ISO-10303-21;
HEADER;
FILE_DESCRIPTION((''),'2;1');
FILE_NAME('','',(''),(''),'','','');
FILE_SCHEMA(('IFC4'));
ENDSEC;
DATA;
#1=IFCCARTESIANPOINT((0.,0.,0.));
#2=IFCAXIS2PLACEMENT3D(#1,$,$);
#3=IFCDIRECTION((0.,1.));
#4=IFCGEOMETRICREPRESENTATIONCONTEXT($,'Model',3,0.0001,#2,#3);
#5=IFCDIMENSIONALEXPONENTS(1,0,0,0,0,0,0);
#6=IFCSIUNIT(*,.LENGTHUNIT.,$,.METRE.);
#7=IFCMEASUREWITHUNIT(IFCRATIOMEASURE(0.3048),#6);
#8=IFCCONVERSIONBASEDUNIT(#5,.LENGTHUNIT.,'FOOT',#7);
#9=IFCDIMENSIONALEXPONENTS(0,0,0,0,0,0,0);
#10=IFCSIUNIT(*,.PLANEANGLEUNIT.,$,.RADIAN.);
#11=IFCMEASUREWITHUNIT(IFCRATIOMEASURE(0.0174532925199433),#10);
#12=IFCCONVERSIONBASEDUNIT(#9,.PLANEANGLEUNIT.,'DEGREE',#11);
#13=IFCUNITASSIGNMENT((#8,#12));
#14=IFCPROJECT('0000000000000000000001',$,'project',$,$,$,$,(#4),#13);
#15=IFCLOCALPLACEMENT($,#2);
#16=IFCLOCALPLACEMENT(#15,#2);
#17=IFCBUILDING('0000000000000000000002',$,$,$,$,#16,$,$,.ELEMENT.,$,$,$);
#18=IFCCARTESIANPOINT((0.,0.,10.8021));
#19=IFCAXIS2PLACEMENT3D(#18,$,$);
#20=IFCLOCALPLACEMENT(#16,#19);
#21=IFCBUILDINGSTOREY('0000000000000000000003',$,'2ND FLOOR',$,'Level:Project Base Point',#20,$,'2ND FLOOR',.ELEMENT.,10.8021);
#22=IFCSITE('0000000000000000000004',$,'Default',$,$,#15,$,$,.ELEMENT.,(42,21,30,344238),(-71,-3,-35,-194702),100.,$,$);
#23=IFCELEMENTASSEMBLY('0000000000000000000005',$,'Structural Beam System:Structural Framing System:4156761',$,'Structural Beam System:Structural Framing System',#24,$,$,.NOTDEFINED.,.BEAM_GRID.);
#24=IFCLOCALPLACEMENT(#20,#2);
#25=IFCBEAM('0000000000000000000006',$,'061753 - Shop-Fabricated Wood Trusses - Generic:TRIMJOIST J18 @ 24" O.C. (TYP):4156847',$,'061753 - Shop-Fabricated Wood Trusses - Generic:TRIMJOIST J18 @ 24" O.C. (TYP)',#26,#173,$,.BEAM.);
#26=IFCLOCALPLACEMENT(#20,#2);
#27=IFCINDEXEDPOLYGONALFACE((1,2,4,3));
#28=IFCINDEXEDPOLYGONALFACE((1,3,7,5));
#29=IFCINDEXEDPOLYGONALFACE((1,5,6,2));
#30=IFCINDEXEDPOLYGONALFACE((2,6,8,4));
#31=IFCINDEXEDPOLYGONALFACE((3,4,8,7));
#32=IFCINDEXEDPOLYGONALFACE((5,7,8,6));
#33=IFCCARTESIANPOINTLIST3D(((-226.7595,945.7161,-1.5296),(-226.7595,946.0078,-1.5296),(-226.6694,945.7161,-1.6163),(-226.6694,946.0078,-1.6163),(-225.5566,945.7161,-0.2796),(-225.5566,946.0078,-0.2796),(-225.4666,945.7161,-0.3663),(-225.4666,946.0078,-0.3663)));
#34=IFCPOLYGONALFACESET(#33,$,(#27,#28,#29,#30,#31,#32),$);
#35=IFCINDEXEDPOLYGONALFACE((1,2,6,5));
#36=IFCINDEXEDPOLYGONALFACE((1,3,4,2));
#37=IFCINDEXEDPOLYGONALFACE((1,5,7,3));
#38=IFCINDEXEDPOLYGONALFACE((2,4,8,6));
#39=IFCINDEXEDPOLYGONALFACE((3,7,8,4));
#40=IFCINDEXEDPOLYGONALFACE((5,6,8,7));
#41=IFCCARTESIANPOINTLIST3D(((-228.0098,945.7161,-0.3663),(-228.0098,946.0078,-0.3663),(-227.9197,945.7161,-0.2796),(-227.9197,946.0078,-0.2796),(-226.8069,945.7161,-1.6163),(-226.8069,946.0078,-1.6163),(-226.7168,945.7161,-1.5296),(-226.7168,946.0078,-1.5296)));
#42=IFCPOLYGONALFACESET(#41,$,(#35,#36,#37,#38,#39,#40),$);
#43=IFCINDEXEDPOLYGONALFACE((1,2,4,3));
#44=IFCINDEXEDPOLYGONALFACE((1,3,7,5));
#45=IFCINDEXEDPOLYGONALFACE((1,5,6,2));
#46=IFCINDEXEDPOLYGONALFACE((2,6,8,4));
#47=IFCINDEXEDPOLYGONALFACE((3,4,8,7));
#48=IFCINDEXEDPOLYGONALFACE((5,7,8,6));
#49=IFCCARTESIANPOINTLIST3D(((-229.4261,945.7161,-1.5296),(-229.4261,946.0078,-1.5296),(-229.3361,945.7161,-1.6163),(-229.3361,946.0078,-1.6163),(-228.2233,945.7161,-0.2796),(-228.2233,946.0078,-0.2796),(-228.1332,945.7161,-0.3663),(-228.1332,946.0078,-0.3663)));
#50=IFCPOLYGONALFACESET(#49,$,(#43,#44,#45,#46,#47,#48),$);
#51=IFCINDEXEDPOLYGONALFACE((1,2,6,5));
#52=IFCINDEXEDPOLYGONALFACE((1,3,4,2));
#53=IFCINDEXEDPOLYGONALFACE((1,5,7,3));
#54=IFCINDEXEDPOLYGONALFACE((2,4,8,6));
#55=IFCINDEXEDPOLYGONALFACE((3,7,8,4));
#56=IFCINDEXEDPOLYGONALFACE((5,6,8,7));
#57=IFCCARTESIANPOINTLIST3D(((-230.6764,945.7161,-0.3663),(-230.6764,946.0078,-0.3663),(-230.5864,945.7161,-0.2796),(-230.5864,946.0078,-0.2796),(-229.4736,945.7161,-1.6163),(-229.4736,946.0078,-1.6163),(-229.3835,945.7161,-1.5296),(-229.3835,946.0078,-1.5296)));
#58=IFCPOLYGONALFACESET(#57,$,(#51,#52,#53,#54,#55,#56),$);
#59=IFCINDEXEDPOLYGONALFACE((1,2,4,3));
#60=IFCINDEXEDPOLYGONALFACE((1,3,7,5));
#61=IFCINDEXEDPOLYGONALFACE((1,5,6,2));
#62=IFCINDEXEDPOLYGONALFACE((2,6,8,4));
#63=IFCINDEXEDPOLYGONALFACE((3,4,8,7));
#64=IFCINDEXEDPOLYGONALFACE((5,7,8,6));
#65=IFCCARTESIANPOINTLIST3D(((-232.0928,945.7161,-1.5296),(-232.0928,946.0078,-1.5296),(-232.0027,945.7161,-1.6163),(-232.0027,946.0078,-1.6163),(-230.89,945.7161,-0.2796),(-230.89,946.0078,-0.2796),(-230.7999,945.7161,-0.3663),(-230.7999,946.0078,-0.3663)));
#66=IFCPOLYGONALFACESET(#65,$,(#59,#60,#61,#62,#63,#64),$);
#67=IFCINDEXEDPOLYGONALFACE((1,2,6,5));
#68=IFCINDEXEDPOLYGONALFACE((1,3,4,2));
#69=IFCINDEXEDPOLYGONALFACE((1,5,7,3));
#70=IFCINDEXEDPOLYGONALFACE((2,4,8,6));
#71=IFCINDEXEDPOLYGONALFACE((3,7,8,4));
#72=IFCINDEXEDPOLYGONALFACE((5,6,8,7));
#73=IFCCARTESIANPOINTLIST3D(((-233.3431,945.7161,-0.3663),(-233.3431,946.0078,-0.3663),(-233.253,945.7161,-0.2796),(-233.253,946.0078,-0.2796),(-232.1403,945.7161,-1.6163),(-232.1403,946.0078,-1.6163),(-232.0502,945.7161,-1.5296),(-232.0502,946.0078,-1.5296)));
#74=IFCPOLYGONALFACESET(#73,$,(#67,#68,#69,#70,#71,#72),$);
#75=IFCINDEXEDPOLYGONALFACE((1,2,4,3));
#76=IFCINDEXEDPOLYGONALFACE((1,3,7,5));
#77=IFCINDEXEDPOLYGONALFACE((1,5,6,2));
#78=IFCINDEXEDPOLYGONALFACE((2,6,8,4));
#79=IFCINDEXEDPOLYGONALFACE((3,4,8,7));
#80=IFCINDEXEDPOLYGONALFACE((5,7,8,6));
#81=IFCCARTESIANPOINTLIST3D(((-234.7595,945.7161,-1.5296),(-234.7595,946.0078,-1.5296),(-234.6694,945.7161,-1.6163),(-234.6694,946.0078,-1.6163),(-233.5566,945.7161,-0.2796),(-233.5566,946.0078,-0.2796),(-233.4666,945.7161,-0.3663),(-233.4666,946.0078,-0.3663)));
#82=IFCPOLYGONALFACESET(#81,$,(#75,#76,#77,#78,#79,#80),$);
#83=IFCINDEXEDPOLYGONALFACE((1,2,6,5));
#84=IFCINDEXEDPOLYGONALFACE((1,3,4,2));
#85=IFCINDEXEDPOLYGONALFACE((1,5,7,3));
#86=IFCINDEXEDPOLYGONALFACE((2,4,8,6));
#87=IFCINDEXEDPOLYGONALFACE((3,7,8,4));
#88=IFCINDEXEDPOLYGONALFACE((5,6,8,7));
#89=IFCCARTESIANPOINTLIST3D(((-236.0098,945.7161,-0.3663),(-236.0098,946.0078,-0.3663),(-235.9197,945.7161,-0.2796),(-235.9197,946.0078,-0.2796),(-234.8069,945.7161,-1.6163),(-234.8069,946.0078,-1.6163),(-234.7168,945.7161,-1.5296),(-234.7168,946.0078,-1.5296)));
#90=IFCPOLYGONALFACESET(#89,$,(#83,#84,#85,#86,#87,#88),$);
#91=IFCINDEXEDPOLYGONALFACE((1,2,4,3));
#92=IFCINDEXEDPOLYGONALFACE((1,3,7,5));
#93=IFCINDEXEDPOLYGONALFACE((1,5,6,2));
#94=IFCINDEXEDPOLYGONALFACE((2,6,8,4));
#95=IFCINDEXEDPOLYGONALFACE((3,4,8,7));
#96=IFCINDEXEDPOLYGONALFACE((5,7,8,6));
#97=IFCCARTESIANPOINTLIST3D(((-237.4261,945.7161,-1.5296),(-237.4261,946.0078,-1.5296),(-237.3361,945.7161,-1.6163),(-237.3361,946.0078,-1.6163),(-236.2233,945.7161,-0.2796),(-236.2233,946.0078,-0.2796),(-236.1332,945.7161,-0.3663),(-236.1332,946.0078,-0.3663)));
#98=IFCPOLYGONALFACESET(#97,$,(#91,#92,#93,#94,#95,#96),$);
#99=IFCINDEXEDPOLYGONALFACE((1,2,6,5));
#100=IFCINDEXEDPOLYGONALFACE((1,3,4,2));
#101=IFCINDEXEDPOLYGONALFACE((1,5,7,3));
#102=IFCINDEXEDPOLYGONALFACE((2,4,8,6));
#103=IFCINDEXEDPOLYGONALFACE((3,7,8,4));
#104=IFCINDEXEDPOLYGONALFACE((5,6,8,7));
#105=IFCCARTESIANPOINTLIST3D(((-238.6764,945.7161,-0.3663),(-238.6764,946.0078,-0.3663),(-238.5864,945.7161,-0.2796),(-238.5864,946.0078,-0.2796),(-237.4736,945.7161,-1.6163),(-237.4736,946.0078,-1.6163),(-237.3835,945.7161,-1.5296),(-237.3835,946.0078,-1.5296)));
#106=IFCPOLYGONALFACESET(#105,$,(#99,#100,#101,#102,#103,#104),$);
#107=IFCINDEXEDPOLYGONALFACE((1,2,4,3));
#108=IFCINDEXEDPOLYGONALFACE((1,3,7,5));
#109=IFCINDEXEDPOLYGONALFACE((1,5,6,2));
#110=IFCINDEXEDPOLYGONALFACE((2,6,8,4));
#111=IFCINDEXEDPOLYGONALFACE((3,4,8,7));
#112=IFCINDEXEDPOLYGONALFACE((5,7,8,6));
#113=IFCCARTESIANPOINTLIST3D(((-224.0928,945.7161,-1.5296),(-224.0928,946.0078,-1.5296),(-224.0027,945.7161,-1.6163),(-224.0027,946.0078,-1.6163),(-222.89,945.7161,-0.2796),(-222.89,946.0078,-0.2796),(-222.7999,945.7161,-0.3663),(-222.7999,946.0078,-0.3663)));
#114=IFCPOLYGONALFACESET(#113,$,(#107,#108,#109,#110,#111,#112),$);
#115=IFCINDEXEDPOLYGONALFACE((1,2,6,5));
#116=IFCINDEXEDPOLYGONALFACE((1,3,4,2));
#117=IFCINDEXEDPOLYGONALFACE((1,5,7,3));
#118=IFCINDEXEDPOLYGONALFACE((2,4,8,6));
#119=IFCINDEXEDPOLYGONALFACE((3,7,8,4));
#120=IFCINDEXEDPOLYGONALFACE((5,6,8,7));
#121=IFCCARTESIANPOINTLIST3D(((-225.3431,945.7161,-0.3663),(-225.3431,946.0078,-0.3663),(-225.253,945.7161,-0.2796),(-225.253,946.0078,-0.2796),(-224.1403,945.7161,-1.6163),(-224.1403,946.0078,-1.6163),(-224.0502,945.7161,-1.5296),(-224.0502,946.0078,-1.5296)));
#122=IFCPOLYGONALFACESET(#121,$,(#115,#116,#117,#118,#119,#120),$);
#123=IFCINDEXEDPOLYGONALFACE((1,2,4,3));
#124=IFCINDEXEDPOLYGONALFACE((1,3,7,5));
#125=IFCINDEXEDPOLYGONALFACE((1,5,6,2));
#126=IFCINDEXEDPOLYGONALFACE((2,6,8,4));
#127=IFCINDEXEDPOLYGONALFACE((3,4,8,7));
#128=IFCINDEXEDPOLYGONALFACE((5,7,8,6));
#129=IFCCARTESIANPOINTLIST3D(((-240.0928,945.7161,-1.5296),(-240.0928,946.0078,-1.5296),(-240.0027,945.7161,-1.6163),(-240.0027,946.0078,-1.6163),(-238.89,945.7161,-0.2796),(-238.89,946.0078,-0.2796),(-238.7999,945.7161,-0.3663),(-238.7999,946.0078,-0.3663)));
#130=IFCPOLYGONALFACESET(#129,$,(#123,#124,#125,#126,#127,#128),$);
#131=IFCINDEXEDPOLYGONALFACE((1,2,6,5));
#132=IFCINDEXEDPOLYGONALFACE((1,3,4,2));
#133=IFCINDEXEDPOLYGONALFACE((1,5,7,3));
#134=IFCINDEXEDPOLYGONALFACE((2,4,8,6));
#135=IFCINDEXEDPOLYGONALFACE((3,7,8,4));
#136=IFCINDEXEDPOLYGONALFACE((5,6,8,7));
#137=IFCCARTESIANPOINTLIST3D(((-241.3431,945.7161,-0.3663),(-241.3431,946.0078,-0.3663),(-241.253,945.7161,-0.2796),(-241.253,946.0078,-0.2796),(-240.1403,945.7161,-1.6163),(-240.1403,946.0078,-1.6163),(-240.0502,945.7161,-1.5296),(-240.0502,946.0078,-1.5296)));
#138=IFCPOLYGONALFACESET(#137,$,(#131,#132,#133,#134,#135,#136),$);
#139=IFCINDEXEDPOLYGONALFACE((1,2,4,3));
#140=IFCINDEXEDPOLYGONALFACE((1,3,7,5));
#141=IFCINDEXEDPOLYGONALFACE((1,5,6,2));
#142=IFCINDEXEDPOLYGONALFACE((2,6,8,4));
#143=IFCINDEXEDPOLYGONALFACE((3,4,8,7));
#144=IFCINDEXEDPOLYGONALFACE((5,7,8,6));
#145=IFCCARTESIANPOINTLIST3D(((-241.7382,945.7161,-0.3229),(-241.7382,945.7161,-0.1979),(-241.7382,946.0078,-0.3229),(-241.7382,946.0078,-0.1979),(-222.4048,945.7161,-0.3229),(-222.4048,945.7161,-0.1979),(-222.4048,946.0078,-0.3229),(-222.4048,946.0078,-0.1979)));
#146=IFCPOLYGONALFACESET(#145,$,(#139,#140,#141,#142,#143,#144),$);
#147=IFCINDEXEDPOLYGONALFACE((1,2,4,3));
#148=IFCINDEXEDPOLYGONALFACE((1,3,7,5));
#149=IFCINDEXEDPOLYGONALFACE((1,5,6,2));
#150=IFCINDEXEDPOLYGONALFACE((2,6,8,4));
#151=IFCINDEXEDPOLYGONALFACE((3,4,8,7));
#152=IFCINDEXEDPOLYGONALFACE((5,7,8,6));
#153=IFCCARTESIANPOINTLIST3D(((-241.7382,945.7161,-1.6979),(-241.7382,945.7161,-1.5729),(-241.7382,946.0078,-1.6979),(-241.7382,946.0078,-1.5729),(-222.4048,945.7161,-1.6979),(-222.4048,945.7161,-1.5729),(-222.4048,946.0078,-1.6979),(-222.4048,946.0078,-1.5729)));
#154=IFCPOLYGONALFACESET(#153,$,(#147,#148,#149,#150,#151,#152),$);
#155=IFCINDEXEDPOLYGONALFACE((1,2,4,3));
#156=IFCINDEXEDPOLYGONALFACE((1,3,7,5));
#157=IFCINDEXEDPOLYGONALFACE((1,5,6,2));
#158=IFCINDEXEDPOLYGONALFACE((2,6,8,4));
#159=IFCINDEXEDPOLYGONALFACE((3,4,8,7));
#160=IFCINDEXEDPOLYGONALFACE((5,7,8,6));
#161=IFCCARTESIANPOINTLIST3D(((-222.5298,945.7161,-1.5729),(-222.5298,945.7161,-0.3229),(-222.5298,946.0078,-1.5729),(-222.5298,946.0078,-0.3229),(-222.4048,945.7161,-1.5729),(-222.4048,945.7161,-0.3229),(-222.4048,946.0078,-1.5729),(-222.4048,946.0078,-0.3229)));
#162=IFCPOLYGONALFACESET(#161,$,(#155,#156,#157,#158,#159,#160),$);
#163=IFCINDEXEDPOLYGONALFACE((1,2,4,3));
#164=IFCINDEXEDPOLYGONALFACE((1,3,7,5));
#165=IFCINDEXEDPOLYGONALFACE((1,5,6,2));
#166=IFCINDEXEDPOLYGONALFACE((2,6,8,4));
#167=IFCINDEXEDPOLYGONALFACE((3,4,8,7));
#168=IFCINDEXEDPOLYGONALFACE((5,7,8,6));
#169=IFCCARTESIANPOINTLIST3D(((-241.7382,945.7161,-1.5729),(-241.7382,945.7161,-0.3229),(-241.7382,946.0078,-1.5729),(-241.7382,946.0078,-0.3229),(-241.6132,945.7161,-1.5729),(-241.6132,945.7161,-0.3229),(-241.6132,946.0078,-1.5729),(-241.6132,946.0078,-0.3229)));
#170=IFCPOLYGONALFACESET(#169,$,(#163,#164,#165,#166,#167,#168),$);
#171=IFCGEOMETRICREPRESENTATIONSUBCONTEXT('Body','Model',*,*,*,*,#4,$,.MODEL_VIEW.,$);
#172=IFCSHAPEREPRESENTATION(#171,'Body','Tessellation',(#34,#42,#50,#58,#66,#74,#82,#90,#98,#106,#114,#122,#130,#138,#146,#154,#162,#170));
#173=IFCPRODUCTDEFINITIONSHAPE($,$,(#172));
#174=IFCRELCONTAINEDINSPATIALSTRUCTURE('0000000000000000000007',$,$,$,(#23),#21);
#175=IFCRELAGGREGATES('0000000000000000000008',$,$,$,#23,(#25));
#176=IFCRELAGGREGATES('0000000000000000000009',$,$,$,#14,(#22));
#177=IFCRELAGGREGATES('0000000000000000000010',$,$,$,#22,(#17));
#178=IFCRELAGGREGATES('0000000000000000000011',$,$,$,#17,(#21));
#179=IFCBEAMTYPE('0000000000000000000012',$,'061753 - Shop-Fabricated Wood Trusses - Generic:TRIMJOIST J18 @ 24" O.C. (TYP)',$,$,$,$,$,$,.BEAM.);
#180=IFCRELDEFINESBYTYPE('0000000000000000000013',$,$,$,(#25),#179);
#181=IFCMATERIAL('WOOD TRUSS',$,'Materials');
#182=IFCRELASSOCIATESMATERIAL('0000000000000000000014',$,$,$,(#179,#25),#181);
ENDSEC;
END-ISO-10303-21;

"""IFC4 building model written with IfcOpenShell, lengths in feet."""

from ifc_helpers import new_model, entity, si_unit, converted_unit, direction, frame, frame_2d, origin, origin_2d_with_axis, place, context, subcontext, project, spatial, rectangle, extrude, source, transform, mapped, material, material_profile, profile_set, profile_usage, type_object, type_shapes, element, aggregate, save


model = new_model("IFC4")

# Units and contexts
model_context = context("Model", 3, precision=0.0001, world=origin(), true_north=direction((0.0, 1.0)))
body_context = subcontext(model_context, "Body", "Model", "MODEL_VIEW")
ifc_project = project(units=[converted_unit("LENGTHUNIT", "FOOT", entity("IfcRatioMeasure", 0.3048), si_unit("LENGTHUNIT", "METRE"), dimensions=[1, 0, 0, 0, 0, 0, 0]), converted_unit("PLANEANGLEUNIT", "DEGREE", entity("IfcRatioMeasure", 0.0174532925199433), si_unit("PLANEANGLEUNIT", "RADIAN"), dimensions=[0, 0, 0, 0, 0, 0, 0])], contexts=[model_context])

# Site, building, storey
site_placement = place(None, origin())
site = spatial("IfcSite", under=ifc_project, at=site_placement, Name="Default", CompositionType="ELEMENT", RefLatitude=(42, 21, 30, 344238), RefLongitude=(-71, -3, -35, -194702), RefElevation=100.0)
building_placement = place(site_placement, origin())
building = spatial("IfcBuilding", under=site, at=building_placement, CompositionType="ELEMENT")
storey_placement = place(building_placement, frame((0.0, 0.0, 10.8021)))
storey = spatial("IfcBuildingStorey", under=building, at=storey_placement, Name="2ND FLOOR", ObjectType="Level:Project Base Point", LongName="2ND FLOOR", CompositionType="ELEMENT", Elevation=10.8021)

# Element assembly, beam
assembly_1_placement = place(storey_placement, origin())
assembly_1 = element("IfcElementAssembly", 1, at=assembly_1_placement, inside=storey, Name="Structural Beam System:Structural Framing System:4156761", ObjectType="Structural Beam System:Structural Framing System", AssemblyPlace="NOTDEFINED", PredefinedType="BEAM_GRID")
ifc_material_1 = material(Name="WOOD TRUSS", Category="Materials")
ifc_material_profile_1 = material_profile(ifc_material_1, rectangle(XDim=1.7347, YDim=0.125, at=frame_2d((0.0, 0.0), x_axis=(1.0, 0.0))), Name="TRIMJOIST J18 @ 24\" O.C. (TYP)")
ifc_material_profile_2 = material_profile(ifc_material_1, rectangle(XDim=1.7347, YDim=0.125, at=frame_2d((0.0, 0.0), x_axis=(1.0, 0.0))), Name="TRIMJOIST J18 @ 24\" O.C. (TYP)")
ifc_material_profile_3 = material_profile(ifc_material_1, rectangle(XDim=1.7347, YDim=0.125, at=frame_2d((0.0, 0.0), x_axis=(1.0, 0.0))), Name="TRIMJOIST J18 @ 24\" O.C. (TYP)")
ifc_material_profile_4 = material_profile(ifc_material_1, rectangle(XDim=1.7347, YDim=0.125, at=frame_2d((0.0, 0.0), x_axis=(1.0, 0.0))), Name="TRIMJOIST J18 @ 24\" O.C. (TYP)")
ifc_material_profile_5 = material_profile(ifc_material_1, rectangle(XDim=1.7347, YDim=0.125, at=frame_2d((0.0, 0.0), x_axis=(1.0, 0.0))), Name="TRIMJOIST J18 @ 24\" O.C. (TYP)")
ifc_material_profile_6 = material_profile(ifc_material_1, rectangle(XDim=1.7347, YDim=0.125, at=frame_2d((0.0, 0.0), x_axis=(1.0, 0.0))), Name="TRIMJOIST J18 @ 24\" O.C. (TYP)")
ifc_material_profile_7 = material_profile(ifc_material_1, rectangle(XDim=1.7347, YDim=0.125, at=frame_2d((0.0, 0.0), x_axis=(1.0, 0.0))), Name="TRIMJOIST J18 @ 24\" O.C. (TYP)")
ifc_material_profile_8 = material_profile(ifc_material_1, rectangle(XDim=1.7347, YDim=0.125, at=frame_2d((0.0, 0.0), x_axis=(1.0, 0.0))), Name="TRIMJOIST J18 @ 24\" O.C. (TYP)")
ifc_material_profile_9 = material_profile(ifc_material_1, rectangle(XDim=1.7347, YDim=0.125, at=frame_2d((0.0, 0.0), x_axis=(1.0, 0.0))), Name="TRIMJOIST J18 @ 24\" O.C. (TYP)")
ifc_material_profile_10 = material_profile(ifc_material_1, rectangle(XDim=1.7347, YDim=0.125, at=origin_2d_with_axis()), Name="TRIMJOIST J18 @ 24\" O.C. (TYP)")
ifc_material_profile_11 = material_profile(ifc_material_1, rectangle(XDim=0.125, YDim=0.2917, at=origin_2d_with_axis()), Name="TRIMJOIST J18 @ 24\" O.C. (TYP)")
ifc_material_profile_12 = material_profile(ifc_material_1, rectangle(XDim=0.125, YDim=0.2917, at=origin_2d_with_axis()), Name="TRIMJOIST J18 @ 24\" O.C. (TYP)")
ifc_material_profile_13 = material_profile(ifc_material_1, rectangle(XDim=1.25, YDim=0.2917, at=origin_2d_with_axis()), Name="TRIMJOIST J18 @ 24\" O.C. (TYP)")
ifc_material_profile_14 = material_profile(ifc_material_1, rectangle(XDim=1.25, YDim=0.2917, at=origin_2d_with_axis()), Name="TRIMJOIST J18 @ 24\" O.C. (TYP)")
ifc_profile_set_1 = profile_set([ifc_material_profile_1, ifc_material_profile_2, ifc_material_profile_3, ifc_material_profile_4, ifc_material_profile_5, ifc_material_profile_6, ifc_material_profile_7, ifc_material_profile_8, ifc_material_profile_9, ifc_material_profile_10, ifc_material_profile_11, ifc_material_profile_12, ifc_material_profile_13, ifc_material_profile_14], Name="TRIMJOIST J18 @ 24\" O.C. (TYP)")
beam_type_1 = type_object("IfcBeamType", Name="061753 - Shop-Fabricated Wood Trusses - Generic:TRIMJOIST J18 @ 24\" O.C. (TYP)", PredefinedType="BEAM", material=ifc_profile_set_1)
shared_shape_1 = source(origin(), body_context, "Body", "SweptSolid", [
    extrude(rectangle(XDim=1.7347, YDim=0.125, at=frame_2d((0.0, 0.0), x_axis=(1.0, 0.0))), frame((5.9585, -0.1458, 0.0), z_axis=(0.0, 1.0, 0.0), x_axis=(0.693383, 0.0, 0.720569)), (0.0, 0.0, 1.0), 0.2917),
    extrude(rectangle(XDim=1.7347, YDim=0.125, at=origin_2d_with_axis()), frame((4.7082, -0.1458, 0.0), z_axis=(0.0, 1.0, 0.0), x_axis=(0.693383, 0.0, -0.720569)), (0.0, 0.0, 1.0), 0.2917),
    extrude(rectangle(XDim=1.7347, YDim=0.125, at=frame_2d((0.0, 0.0), x_axis=(1.0, 0.0))), frame((3.2918, -0.1458, 0.0), z_axis=(0.0, 1.0, 0.0), x_axis=(0.693383, 0.0, 0.720569)), (0.0, 0.0, 1.0), 0.2917),
    extrude(rectangle(XDim=1.7347, YDim=0.125, at=frame_2d((0.0, 0.0), x_axis=(1.0, 0.0))), frame((2.0415, -0.1458, 0.0), z_axis=(0.0, 1.0, 0.0), x_axis=(0.693383, 0.0, -0.720569)), (0.0, 0.0, 1.0), 0.2917),
    extrude(rectangle(XDim=1.7347, YDim=0.125, at=frame_2d((0.0, 0.0), x_axis=(1.0, 0.0))), frame((0.6251, -0.1458, 0.0), z_axis=(0.0, 1.0, 0.0), x_axis=(0.693383, 0.0, 0.720569)), (0.0, 0.0, 1.0), 0.2917),
    extrude(rectangle(XDim=1.7347, YDim=0.125, at=frame_2d((0.0, 0.0), x_axis=(1.0, 0.0))), frame((-0.6251, -0.1458, 0.0), z_axis=(0.0, 1.0, 0.0), x_axis=(0.693383, 0.0, -0.720569)), (0.0, 0.0, 1.0), 0.2917),
    extrude(rectangle(XDim=1.7347, YDim=0.125, at=frame_2d((0.0, 0.0), x_axis=(1.0, 0.0))), frame((-2.0415, -0.1458, 0.0), z_axis=(0.0, 1.0, 0.0), x_axis=(0.693383, 0.0, 0.720569)), (0.0, 0.0, 1.0), 0.2917),
    extrude(rectangle(XDim=1.7347, YDim=0.125, at=origin_2d_with_axis()), frame((-3.2918, -0.1458, 0.0), z_axis=(0.0, 1.0, 0.0), x_axis=(0.693383, 0.0, -0.720569)), (0.0, 0.0, 1.0), 0.2917),
    extrude(rectangle(XDim=1.7347, YDim=0.125, at=frame_2d((0.0, 0.0), x_axis=(1.0, 0.0))), frame((-4.7082, -0.1458, 0.0), z_axis=(0.0, 1.0, 0.0), x_axis=(0.693383, 0.0, 0.720569)), (0.0, 0.0, 1.0), 0.2917),
    extrude(rectangle(XDim=1.7347, YDim=0.125, at=frame_2d((0.0, 0.0), x_axis=(1.0, 0.0))), frame((-5.9585, -0.1458, 0.0), z_axis=(0.0, 1.0, 0.0), x_axis=(0.693383, 0.0, -0.720569)), (0.0, 0.0, 1.0), 0.2917),
    extrude(rectangle(XDim=1.7347, YDim=0.125, at=frame_2d((0.0, 0.0), x_axis=(1.0, 0.0))), frame((8.6251, -0.1458, 0.0), z_axis=(0.0, 1.0, 0.0), x_axis=(0.693383, 0.0, 0.720569)), (0.0, 0.0, 1.0), 0.2917),
    extrude(rectangle(XDim=1.7347, YDim=0.125, at=origin_2d_with_axis()), frame((7.3749, -0.1458, 0.0), z_axis=(0.0, 1.0, 0.0), x_axis=(0.693383, 0.0, -0.720569)), (0.0, 0.0, 1.0), 0.2917),
    extrude(rectangle(XDim=1.7347, YDim=0.125, at=frame_2d((0.0, 0.0), x_axis=(1.0, 0.0))), frame((-7.3749, -0.1458, 0.0), z_axis=(0.0, 1.0, 0.0), x_axis=(0.693383, 0.0, 0.720569)), (0.0, 0.0, 1.0), 0.2917),
    extrude(rectangle(XDim=1.7347, YDim=0.125, at=origin_2d_with_axis()), frame((-8.6251, -0.1458, 0.0), z_axis=(0.0, 1.0, 0.0), x_axis=(0.693383, 0.0, -0.720569)), (0.0, 0.0, 1.0), 0.2917),
    extrude(rectangle(XDim=0.125, YDim=0.2917, at=origin_2d_with_axis()), frame((-9.6667, 0.0, 0.6875), z_axis=(1.0, 0.0, 0.0), x_axis=(0.0, 0.0, -1.0)), (0.0, 0.0, 1.0), 19.3333),
    extrude(rectangle(XDim=0.125, YDim=0.2917, at=origin_2d_with_axis()), frame((-9.6667, 0.0, -0.6875), z_axis=(1.0, 0.0, 0.0), x_axis=(0.0, 0.0, -1.0)), (0.0, 0.0, 1.0), 19.3333),
    extrude(rectangle(XDim=1.25, YDim=0.2917, at=origin_2d_with_axis()), frame((9.5417, 0.0, 0.0), z_axis=(1.0, 0.0, 0.0), x_axis=(0.0, 0.0, -1.0)), (0.0, 0.0, 1.0), 0.125),
    extrude(rectangle(XDim=1.25, YDim=0.2917, at=origin_2d_with_axis()), frame((-9.6667, 0.0, 0.0), z_axis=(1.0, 0.0, 0.0), x_axis=(0.0, 0.0, -1.0)), (0.0, 0.0, 1.0), 0.125),
])
type_shapes(beam_type_1, [shared_shape_1])
ifc_profile_usage_1 = profile_usage(ifc_profile_set_1, cardinal=8)
beam_1_placement = place(assembly_1_placement, frame((-232.0715, 945.8619, -0.9479)))
beam_1 = element("IfcBeam", 2, at=beam_1_placement, type_object=beam_type_1, material=ifc_profile_usage_1, Name="061753 - Shop-Fabricated Wood Trusses - Generic:TRIMJOIST J18 @ 24\" O.C. (TYP):4156847", ObjectType="061753 - Shop-Fabricated Wood Trusses - Generic:TRIMJOIST J18 @ 24\" O.C. (TYP)", PredefinedType="BEAM", context=body_context, shape_type="MappedRepresentation", body=[
    mapped(shared_shape_1, transform((0.0, 0.0, 0.0), scale=1.0)),
])
aggregate(assembly_1, [beam_1])

save(model, "model.ifc")
